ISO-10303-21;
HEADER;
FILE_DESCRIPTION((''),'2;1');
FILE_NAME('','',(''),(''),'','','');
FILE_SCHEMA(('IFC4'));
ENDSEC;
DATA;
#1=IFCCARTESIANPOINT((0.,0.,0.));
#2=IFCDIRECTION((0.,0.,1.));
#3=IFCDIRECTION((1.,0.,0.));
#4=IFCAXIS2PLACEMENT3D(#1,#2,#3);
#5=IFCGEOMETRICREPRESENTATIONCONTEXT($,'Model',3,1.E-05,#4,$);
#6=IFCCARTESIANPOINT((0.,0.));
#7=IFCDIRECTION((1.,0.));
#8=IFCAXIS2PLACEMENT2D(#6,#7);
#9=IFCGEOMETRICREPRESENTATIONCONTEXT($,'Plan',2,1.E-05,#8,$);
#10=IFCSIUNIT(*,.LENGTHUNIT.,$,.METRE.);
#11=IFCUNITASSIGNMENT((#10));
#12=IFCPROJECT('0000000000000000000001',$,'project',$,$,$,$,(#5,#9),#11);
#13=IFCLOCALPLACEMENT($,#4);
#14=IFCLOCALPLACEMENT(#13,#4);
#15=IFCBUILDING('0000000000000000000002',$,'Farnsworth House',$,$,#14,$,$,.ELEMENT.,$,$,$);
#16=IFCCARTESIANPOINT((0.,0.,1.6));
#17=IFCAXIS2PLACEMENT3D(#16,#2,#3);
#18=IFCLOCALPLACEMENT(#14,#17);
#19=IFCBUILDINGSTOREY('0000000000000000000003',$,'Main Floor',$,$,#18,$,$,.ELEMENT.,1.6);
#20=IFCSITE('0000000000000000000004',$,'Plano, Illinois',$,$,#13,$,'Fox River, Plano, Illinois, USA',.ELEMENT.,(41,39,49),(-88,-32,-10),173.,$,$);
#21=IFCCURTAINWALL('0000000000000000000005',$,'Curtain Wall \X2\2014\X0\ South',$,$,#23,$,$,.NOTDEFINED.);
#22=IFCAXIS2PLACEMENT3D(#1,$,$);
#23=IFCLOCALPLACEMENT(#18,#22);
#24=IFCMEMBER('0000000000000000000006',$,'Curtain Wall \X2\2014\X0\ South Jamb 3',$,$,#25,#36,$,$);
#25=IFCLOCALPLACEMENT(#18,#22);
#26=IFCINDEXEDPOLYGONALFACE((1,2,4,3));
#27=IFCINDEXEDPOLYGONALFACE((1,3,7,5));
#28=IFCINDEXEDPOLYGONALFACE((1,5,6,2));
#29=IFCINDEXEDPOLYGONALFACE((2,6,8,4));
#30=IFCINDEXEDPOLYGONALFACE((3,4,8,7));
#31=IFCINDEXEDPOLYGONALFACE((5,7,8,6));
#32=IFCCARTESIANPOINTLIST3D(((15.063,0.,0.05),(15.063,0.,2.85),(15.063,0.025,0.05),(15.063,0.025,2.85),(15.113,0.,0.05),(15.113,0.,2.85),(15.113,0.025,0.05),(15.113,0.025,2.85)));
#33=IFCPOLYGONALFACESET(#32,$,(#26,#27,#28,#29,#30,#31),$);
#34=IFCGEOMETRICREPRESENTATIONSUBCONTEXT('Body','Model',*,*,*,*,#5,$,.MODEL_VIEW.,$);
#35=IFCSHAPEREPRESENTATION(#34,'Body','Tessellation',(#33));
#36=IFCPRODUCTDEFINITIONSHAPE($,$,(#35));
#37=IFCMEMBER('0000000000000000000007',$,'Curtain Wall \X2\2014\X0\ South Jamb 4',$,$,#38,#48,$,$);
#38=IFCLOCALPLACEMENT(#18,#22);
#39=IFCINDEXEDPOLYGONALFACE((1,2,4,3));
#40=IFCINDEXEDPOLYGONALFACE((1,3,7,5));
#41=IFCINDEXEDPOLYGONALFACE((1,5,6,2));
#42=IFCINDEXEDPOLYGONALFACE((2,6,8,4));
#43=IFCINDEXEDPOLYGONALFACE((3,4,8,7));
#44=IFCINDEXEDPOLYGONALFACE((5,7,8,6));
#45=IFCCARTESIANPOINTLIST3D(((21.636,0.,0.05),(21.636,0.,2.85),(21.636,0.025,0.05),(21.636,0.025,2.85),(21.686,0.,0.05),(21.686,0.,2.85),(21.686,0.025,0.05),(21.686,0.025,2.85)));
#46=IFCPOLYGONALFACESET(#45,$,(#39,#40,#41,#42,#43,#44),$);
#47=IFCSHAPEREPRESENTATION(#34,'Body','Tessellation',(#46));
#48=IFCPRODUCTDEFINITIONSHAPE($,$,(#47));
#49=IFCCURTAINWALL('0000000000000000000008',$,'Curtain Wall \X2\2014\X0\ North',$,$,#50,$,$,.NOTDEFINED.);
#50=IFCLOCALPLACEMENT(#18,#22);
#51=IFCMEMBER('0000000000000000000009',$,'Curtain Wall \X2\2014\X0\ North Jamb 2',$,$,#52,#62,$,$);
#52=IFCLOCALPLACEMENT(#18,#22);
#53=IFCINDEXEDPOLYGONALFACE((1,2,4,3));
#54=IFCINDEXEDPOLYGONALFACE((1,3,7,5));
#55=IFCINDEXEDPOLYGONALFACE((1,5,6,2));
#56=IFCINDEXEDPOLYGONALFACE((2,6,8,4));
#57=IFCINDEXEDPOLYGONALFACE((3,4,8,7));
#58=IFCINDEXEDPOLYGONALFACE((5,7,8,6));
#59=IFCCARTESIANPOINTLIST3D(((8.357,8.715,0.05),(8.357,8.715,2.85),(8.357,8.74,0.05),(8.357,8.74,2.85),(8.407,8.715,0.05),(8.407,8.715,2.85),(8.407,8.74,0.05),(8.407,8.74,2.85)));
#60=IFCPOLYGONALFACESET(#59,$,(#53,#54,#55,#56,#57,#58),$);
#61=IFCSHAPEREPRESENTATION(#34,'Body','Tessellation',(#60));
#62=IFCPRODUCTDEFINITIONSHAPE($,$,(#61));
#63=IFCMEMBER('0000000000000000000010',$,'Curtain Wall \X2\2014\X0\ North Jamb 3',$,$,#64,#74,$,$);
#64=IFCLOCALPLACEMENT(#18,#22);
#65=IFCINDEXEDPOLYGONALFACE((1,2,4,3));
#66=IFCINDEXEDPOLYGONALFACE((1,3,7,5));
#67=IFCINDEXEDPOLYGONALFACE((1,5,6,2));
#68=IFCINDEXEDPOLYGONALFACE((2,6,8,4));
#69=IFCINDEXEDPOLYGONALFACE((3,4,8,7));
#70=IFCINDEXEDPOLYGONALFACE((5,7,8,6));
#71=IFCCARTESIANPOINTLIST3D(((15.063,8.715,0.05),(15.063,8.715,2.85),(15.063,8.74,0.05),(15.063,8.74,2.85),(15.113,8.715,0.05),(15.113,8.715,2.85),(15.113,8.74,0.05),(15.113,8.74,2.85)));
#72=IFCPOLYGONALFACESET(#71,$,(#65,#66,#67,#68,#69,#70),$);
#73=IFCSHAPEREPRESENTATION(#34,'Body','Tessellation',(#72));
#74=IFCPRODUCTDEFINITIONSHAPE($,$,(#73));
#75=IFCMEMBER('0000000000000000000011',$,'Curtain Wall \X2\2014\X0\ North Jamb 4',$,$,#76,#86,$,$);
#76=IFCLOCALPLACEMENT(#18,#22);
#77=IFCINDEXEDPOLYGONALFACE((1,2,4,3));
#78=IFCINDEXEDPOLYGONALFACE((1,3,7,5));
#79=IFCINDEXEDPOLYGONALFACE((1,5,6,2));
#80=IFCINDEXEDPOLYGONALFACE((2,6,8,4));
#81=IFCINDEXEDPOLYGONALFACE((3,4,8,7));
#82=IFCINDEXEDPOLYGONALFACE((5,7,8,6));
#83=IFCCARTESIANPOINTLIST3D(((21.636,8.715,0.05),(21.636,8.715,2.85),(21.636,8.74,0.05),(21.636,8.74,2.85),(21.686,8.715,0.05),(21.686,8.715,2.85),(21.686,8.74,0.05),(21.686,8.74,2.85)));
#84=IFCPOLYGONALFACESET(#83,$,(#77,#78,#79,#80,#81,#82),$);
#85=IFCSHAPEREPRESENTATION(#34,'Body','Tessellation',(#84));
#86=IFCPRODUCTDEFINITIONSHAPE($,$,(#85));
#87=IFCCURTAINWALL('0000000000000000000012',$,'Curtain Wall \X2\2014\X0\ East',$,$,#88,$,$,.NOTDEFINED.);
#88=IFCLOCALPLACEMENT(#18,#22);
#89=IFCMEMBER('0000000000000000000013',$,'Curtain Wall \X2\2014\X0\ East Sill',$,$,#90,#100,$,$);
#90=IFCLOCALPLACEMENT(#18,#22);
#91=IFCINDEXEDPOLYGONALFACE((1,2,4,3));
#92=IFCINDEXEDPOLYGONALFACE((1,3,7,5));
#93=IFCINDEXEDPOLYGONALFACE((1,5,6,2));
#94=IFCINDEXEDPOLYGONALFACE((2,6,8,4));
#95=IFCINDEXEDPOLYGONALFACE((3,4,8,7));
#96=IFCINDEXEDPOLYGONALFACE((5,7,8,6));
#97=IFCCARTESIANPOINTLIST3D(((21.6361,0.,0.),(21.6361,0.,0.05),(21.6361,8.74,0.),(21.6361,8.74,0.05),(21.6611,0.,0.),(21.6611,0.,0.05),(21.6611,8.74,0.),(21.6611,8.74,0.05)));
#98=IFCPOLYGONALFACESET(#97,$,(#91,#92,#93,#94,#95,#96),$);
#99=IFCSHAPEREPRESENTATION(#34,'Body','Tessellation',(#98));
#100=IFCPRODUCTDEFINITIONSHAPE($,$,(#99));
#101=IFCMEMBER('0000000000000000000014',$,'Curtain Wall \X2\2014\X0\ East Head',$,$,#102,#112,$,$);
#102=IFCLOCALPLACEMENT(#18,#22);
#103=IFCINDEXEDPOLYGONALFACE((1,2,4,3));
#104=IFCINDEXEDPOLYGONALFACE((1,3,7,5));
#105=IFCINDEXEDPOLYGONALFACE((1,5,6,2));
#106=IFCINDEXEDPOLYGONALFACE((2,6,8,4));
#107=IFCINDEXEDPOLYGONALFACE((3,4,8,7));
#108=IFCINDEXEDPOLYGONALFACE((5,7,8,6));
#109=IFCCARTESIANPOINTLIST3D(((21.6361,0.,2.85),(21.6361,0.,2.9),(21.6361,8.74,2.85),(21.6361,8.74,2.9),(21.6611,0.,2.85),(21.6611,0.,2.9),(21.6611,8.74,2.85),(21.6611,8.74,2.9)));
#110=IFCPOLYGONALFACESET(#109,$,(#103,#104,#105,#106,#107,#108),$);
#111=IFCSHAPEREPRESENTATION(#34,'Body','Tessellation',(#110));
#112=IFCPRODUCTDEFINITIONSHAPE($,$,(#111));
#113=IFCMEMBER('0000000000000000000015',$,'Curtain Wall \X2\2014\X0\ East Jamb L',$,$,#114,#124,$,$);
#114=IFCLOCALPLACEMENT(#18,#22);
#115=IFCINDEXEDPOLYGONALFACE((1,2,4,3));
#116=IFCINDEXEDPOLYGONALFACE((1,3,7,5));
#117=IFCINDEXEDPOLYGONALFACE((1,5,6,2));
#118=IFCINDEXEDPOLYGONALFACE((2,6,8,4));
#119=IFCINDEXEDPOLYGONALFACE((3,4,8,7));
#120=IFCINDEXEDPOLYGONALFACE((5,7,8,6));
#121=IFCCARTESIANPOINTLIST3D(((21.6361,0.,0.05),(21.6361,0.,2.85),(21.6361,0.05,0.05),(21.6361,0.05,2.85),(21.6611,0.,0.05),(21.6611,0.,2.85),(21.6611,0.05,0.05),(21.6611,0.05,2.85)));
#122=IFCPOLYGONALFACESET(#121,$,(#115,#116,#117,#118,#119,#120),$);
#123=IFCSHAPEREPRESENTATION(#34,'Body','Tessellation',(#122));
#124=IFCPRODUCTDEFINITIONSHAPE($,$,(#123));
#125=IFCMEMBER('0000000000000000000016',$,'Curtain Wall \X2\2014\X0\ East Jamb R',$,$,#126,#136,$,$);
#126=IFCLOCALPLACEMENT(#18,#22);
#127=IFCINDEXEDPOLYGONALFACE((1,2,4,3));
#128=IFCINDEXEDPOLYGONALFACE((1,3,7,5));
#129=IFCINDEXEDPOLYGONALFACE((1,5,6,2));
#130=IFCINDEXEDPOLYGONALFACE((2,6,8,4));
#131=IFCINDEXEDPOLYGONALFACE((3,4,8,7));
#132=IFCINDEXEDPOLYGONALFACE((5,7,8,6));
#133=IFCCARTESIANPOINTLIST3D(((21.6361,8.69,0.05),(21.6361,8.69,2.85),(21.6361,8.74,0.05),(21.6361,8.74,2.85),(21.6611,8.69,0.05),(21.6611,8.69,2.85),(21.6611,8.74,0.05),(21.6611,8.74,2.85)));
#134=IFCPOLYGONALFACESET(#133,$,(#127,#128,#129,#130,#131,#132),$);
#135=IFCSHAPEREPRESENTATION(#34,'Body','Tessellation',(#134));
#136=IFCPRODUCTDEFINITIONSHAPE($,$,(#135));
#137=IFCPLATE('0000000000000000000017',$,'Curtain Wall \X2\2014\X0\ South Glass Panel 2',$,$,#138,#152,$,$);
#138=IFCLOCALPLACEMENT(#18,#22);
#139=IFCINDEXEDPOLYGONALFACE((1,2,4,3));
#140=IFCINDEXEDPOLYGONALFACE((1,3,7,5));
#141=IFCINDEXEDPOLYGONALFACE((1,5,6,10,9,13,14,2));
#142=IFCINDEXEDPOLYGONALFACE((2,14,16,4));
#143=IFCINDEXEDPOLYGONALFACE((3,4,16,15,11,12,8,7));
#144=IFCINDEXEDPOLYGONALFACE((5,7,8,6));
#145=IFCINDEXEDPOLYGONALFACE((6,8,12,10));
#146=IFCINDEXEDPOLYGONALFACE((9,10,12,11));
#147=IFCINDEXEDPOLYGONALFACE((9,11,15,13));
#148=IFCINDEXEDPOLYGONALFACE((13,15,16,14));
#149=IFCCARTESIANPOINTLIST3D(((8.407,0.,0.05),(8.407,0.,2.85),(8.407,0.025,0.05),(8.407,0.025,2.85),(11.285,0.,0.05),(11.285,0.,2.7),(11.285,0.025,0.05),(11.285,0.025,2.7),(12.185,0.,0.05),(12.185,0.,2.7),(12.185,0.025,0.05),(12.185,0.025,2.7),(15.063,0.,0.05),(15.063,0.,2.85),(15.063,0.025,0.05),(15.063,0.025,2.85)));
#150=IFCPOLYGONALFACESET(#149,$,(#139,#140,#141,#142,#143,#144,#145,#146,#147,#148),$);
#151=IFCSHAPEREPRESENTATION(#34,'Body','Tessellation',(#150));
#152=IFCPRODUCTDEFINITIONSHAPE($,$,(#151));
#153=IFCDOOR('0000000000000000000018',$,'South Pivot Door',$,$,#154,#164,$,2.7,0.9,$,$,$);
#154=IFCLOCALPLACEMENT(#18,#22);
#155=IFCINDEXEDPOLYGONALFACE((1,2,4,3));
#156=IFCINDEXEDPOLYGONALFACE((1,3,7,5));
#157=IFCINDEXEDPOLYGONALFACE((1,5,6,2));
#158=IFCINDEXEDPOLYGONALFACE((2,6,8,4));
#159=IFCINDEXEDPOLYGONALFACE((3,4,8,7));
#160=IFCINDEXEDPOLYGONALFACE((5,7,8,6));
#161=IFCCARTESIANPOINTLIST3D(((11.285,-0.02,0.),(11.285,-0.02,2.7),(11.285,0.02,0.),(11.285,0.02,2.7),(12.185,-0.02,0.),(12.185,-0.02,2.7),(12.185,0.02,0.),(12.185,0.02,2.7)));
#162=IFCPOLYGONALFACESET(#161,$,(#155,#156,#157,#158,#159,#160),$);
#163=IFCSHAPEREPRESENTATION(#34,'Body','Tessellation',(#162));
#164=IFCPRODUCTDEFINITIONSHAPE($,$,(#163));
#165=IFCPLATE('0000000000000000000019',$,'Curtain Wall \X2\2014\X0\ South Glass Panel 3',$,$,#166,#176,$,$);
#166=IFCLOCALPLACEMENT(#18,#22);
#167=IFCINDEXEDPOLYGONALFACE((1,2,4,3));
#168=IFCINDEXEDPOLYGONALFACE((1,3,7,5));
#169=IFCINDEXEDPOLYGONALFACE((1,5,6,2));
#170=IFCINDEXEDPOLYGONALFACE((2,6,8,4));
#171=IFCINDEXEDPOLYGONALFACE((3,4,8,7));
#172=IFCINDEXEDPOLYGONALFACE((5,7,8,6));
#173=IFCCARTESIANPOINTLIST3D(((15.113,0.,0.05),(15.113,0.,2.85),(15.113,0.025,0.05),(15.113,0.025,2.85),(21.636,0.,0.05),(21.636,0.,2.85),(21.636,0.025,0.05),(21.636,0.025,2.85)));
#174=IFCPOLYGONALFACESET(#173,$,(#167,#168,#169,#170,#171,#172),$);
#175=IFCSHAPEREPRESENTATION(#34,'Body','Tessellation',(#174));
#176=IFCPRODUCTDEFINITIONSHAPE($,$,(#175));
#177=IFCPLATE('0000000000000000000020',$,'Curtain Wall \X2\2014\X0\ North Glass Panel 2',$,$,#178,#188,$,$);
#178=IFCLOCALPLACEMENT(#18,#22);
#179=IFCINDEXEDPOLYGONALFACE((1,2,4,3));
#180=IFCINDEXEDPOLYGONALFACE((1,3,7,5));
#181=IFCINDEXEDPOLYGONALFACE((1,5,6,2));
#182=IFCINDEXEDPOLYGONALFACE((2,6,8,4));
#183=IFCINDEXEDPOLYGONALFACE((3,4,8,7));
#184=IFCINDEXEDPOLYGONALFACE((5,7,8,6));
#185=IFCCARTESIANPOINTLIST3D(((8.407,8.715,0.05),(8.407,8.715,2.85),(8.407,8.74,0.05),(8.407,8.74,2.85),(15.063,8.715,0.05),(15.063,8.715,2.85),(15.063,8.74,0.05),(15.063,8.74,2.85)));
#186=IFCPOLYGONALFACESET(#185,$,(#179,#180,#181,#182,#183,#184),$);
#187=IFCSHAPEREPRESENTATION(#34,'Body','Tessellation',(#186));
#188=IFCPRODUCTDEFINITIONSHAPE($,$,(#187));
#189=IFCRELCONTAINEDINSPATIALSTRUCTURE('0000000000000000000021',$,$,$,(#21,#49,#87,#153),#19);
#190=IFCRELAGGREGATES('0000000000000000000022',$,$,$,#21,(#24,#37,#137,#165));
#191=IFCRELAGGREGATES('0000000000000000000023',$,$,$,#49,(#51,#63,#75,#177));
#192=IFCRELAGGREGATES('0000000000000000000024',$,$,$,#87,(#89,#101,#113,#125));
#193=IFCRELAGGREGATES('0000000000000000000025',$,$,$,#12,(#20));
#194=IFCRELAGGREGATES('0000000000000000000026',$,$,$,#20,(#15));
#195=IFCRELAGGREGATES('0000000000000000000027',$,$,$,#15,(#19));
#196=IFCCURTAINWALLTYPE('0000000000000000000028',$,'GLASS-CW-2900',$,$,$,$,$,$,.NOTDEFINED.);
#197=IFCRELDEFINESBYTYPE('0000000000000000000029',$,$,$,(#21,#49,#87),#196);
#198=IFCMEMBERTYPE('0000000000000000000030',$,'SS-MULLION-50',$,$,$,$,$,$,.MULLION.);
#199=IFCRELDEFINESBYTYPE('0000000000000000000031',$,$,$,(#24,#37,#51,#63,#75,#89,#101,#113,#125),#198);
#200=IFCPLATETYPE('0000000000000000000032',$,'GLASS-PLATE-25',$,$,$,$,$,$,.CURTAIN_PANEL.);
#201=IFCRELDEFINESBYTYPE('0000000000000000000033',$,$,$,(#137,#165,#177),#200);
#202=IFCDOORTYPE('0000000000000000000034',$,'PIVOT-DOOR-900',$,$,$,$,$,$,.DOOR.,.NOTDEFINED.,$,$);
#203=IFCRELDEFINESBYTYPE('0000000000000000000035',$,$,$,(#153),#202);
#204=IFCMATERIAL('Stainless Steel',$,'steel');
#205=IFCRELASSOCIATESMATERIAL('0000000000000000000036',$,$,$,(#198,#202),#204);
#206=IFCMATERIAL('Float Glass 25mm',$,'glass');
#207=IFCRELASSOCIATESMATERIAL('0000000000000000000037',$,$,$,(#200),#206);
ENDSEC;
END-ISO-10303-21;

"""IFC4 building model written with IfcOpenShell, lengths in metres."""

from ifc_helpers import new_model, si_unit, frame, origin_with_axes, origin_2d_with_axis, place, context, subcontext, project, spatial, rectangle, extrude, material, type_object, element, fill, aggregate, save


model = new_model("IFC4")

# Units and contexts
model_context = context("Model", 3, precision=1e-05, world=origin_with_axes())
plan_context = context("Plan", 2, precision=1e-05, world=origin_2d_with_axis())
body_context = subcontext(model_context, "Body", "Model", "MODEL_VIEW")
ifc_project = project(units=[si_unit("LENGTHUNIT", "METRE")], contexts=[model_context, plan_context])

# Site, building, storey
site_placement = place(None, origin_with_axes())
site = spatial("IfcSite", under=ifc_project, at=site_placement, Name="Plano, Illinois", LongName="Fox River, Plano, Illinois, USA", CompositionType="ELEMENT", RefLatitude=(41, 39, 49), RefLongitude=(-88, -32, -10), RefElevation=173.0)
building_placement = place(site_placement, origin_with_axes())
building = spatial("IfcBuilding", under=site, at=building_placement, Name="Farnsworth House", CompositionType="ELEMENT")
storey_placement = place(building_placement, frame((0.0, 0.0, 1.6), z_axis=(0.0, 0.0, 1.0), x_axis=(1.0, 0.0, 0.0)))
storey = spatial("IfcBuildingStorey", under=building, at=storey_placement, Name="Main Floor", CompositionType="ELEMENT", Elevation=1.6)

# Curtain walls, members
curtain_wall_type = type_object("IfcCurtainWallType", Name="GLASS-CW-2900", PredefinedType="NOTDEFINED")
curtain_wall_1_placement = place(storey_placement, frame((1.7839, 0.0, 0.0), z_axis=(0.0, 0.0, 1.0), x_axis=(1.0, 0.0, 0.0)))
curtain_wall_1 = element("IfcCurtainWall", 1, at=curtain_wall_1_placement, inside=storey, type_object=curtain_wall_type, Name="Curtain Wall — South", PredefinedType="NOTDEFINED")
ifc_material_1 = material(Name="Stainless Steel", Category="steel")
member_type = type_object("IfcMemberType", Name="SS-MULLION-50", PredefinedType="MULLION", material=ifc_material_1)
member_1_placement = place(curtain_wall_1_placement, frame((13.279, 0.0, 0.05), z_axis=(0.0, 0.0, 1.0), x_axis=(1.0, 0.0, 0.0)))
member_1 = element("IfcMember", 2, at=member_1_placement, type_object=member_type, Name="Curtain Wall — South Jamb 3", context=body_context, shape_type="SweptSolid", body=[
    extrude(rectangle(XDim=0.05, YDim=0.025, at=origin_2d_with_axis()), frame((0.025, 0.0125, 0.0), z_axis=(0.0, 0.0, 1.0), x_axis=(1.0, 0.0, 0.0)), (0.0, 0.0, 1.0), 2.8),
])
member_2_placement = place(curtain_wall_1_placement, frame((19.8521, 0.0, 0.05), z_axis=(0.0, 0.0, 1.0), x_axis=(1.0, 0.0, 0.0)))
member_2 = element("IfcMember", 3, at=member_2_placement, type_object=member_type, Name="Curtain Wall — South Jamb 4", context=body_context, shape_type="SweptSolid", body=[
    extrude(rectangle(XDim=0.05, YDim=0.025, at=origin_2d_with_axis()), frame((0.025, 0.0125, 0.0), z_axis=(0.0, 0.0, 1.0), x_axis=(1.0, 0.0, 0.0)), (0.0, 0.0, 1.0), 2.8),
])
curtain_wall_2_placement = place(storey_placement, frame((1.7839, 8.715, 0.0), z_axis=(0.0, 0.0, 1.0), x_axis=(1.0, 0.0, 0.0)))
curtain_wall_2 = element("IfcCurtainWall", 4, at=curtain_wall_2_placement, inside=storey, type_object=curtain_wall_type, Name="Curtain Wall — North", PredefinedType="NOTDEFINED")
member_3_placement = place(curtain_wall_2_placement, frame((6.573, 0.0, 0.05), z_axis=(0.0, 0.0, 1.0), x_axis=(1.0, 0.0, 0.0)))
member_3 = element("IfcMember", 5, at=member_3_placement, type_object=member_type, Name="Curtain Wall — North Jamb 2", context=body_context, shape_type="SweptSolid", body=[
    extrude(rectangle(XDim=0.05, YDim=0.025, at=origin_2d_with_axis()), frame((0.025, 0.0125, 0.0), z_axis=(0.0, 0.0, 1.0), x_axis=(1.0, 0.0, 0.0)), (0.0, 0.0, 1.0), 2.8),
])
member_4_placement = place(curtain_wall_2_placement, frame((13.279, 0.0, 0.05), z_axis=(0.0, 0.0, 1.0), x_axis=(1.0, 0.0, 0.0)))
member_4 = element("IfcMember", 6, at=member_4_placement, type_object=member_type, Name="Curtain Wall — North Jamb 3", context=body_context, shape_type="SweptSolid", body=[
    extrude(rectangle(XDim=0.05, YDim=0.025, at=origin_2d_with_axis()), frame((0.025, 0.0125, 0.0), z_axis=(0.0, 0.0, 1.0), x_axis=(1.0, 0.0, 0.0)), (0.0, 0.0, 1.0), 2.8),
])
member_5_placement = place(curtain_wall_2_placement, frame((19.8521, 0.0, 0.05), z_axis=(0.0, 0.0, 1.0), x_axis=(1.0, 0.0, 0.0)))
member_5 = element("IfcMember", 7, at=member_5_placement, type_object=member_type, Name="Curtain Wall — North Jamb 4", context=body_context, shape_type="SweptSolid", body=[
    extrude(rectangle(XDim=0.05, YDim=0.025, at=origin_2d_with_axis()), frame((0.025, 0.0125, 0.0), z_axis=(0.0, 0.0, 1.0), x_axis=(1.0, 0.0, 0.0)), (0.0, 0.0, 1.0), 2.8),
])
curtain_wall_3_placement = place(storey_placement, frame((21.6611, 0.0, 0.0), z_axis=(0.0, 0.0, 1.0), x_axis=(0.0, 1.0, 0.0)))
curtain_wall_3 = element("IfcCurtainWall", 8, at=curtain_wall_3_placement, inside=storey, type_object=curtain_wall_type, Name="Curtain Wall — East", PredefinedType="NOTDEFINED")
member_6_placement = place(curtain_wall_3_placement, origin_with_axes())
member_6 = element("IfcMember", 9, at=member_6_placement, type_object=member_type, Name="Curtain Wall — East Sill", context=body_context, shape_type="SweptSolid", body=[
    extrude(rectangle(XDim=8.74, YDim=0.025, at=origin_2d_with_axis()), frame((4.37, 0.0125, 0.0), z_axis=(0.0, 0.0, 1.0), x_axis=(1.0, 0.0, 0.0)), (0.0, 0.0, 1.0), 0.05),
])
member_7_placement = place(curtain_wall_3_placement, frame((0.0, 0.0, 2.85), z_axis=(0.0, 0.0, 1.0), x_axis=(1.0, 0.0, 0.0)))
member_7 = element("IfcMember", 10, at=member_7_placement, type_object=member_type, Name="Curtain Wall — East Head", context=body_context, shape_type="SweptSolid", body=[
    extrude(rectangle(XDim=8.74, YDim=0.025, at=origin_2d_with_axis()), frame((4.37, 0.0125, 0.0), z_axis=(0.0, 0.0, 1.0), x_axis=(1.0, 0.0, 0.0)), (0.0, 0.0, 1.0), 0.05),
])
member_8_placement = place(curtain_wall_3_placement, frame((0.0, 0.0, 0.05), z_axis=(0.0, 0.0, 1.0), x_axis=(1.0, 0.0, 0.0)))
member_8 = element("IfcMember", 11, at=member_8_placement, type_object=member_type, Name="Curtain Wall — East Jamb L", context=body_context, shape_type="SweptSolid", body=[
    extrude(rectangle(XDim=0.05, YDim=0.025, at=origin_2d_with_axis()), frame((0.025, 0.0125, 0.0), z_axis=(0.0, 0.0, 1.0), x_axis=(1.0, 0.0, 0.0)), (0.0, 0.0, 1.0), 2.8),
])
member_9_placement = place(curtain_wall_3_placement, frame((8.69, 0.0, 0.05), z_axis=(0.0, 0.0, 1.0), x_axis=(1.0, 0.0, 0.0)))
member_9 = element("IfcMember", 12, at=member_9_placement, type_object=member_type, Name="Curtain Wall — East Jamb R", context=body_context, shape_type="SweptSolid", body=[
    extrude(rectangle(XDim=0.05, YDim=0.025, at=origin_2d_with_axis()), frame((0.025, 0.0125, 0.0), z_axis=(0.0, 0.0, 1.0), x_axis=(1.0, 0.0, 0.0)), (0.0, 0.0, 1.0), 2.8),
])

# Plate, opening, door
ifc_material_2 = material(Name="Float Glass 25mm", Category="glass")
plate_type = type_object("IfcPlateType", Name="GLASS-PLATE-25", PredefinedType="CURTAIN_PANEL", material=ifc_material_2)
plate_1_placement = place(curtain_wall_1_placement, frame((6.6231, 0.0, 0.05), z_axis=(0.0, 0.0, 1.0), x_axis=(1.0, 0.0, 0.0)))
plate_1 = element("IfcPlate", 13, at=plate_1_placement, type_object=plate_type, Name="Curtain Wall — South Glass Panel 2", context=body_context, shape_type="SweptSolid", body=[
    extrude(rectangle(XDim=6.656, YDim=0.025, at=origin_2d_with_axis()), frame((3.328, 0.0125, 0.0), z_axis=(0.0, 0.0, 1.0), x_axis=(1.0, 0.0, 0.0)), (0.0, 0.0, 1.0), 2.8),
])
opening_placement = place(curtain_wall_1_placement, frame((9.501, -0.025, 0.0), z_axis=(0.0, 0.0, 1.0), x_axis=(1.0, 0.0, 0.0)))
opening = element("IfcOpeningElement", 14, at=opening_placement, cuts=plate_1, PredefinedType="OPENING", context=body_context, shape_type="SweptSolid", body=[
    extrude(rectangle(XDim=0.9, YDim=0.075, at=origin_2d_with_axis()), frame((0.45, 0.0375, 0.0), z_axis=(0.0, 0.0, 1.0), x_axis=(1.0, 0.0, 0.0)), (0.0, 0.0, 1.0), 2.7),
])
door_type = type_object("IfcDoorType", Name="PIVOT-DOOR-900", OperationType="NOTDEFINED", PredefinedType="DOOR", material=ifc_material_1)
door_placement = place(storey_placement, frame((11.285, -0.02, 0.0), z_axis=(0.0, 0.0, 1.0), x_axis=(1.0, 0.0, 0.0)))
door = element("IfcDoor", 15, at=door_placement, inside=storey, type_object=door_type, Name="South Pivot Door", OverallHeight=2.7, OverallWidth=0.9, context=body_context, shape_type="SweptSolid", body=[
    extrude(rectangle(XDim=0.9, YDim=0.04, at=origin_2d_with_axis()), frame((0.45, 0.02, 0.0), z_axis=(0.0, 0.0, 1.0), x_axis=(1.0, 0.0, 0.0)), (0.0, 0.0, 1.0), 2.7),
])
fill(opening, door)

# Plates
plate_2_placement = place(curtain_wall_1_placement, frame((13.329, 0.0, 0.05), z_axis=(0.0, 0.0, 1.0), x_axis=(1.0, 0.0, 0.0)))
plate_2 = element("IfcPlate", 16, at=plate_2_placement, type_object=plate_type, Name="Curtain Wall — South Glass Panel 3", context=body_context, shape_type="SweptSolid", body=[
    extrude(rectangle(XDim=6.523, YDim=0.025, at=origin_2d_with_axis()), frame((3.2615, 0.0125, 0.0), z_axis=(0.0, 0.0, 1.0), x_axis=(1.0, 0.0, 0.0)), (0.0, 0.0, 1.0), 2.8),
])
aggregate(curtain_wall_1, [member_1, member_2, plate_1, plate_2])
plate_3_placement = place(curtain_wall_2_placement, frame((6.6231, 0.0, 0.05), z_axis=(0.0, 0.0, 1.0), x_axis=(1.0, 0.0, 0.0)))
plate_3 = element("IfcPlate", 17, at=plate_3_placement, type_object=plate_type, Name="Curtain Wall — North Glass Panel 2", context=body_context, shape_type="SweptSolid", body=[
    extrude(rectangle(XDim=6.656, YDim=0.025, at=origin_2d_with_axis()), frame((3.328, 0.0125, 0.0), z_axis=(0.0, 0.0, 1.0), x_axis=(1.0, 0.0, 0.0)), (0.0, 0.0, 1.0), 2.8),
])
aggregate(curtain_wall_2, [member_3, member_4, member_5, plate_3])
aggregate(curtain_wall_3, [member_6, member_7, member_8, member_9])

save(model, "model.ifc")
